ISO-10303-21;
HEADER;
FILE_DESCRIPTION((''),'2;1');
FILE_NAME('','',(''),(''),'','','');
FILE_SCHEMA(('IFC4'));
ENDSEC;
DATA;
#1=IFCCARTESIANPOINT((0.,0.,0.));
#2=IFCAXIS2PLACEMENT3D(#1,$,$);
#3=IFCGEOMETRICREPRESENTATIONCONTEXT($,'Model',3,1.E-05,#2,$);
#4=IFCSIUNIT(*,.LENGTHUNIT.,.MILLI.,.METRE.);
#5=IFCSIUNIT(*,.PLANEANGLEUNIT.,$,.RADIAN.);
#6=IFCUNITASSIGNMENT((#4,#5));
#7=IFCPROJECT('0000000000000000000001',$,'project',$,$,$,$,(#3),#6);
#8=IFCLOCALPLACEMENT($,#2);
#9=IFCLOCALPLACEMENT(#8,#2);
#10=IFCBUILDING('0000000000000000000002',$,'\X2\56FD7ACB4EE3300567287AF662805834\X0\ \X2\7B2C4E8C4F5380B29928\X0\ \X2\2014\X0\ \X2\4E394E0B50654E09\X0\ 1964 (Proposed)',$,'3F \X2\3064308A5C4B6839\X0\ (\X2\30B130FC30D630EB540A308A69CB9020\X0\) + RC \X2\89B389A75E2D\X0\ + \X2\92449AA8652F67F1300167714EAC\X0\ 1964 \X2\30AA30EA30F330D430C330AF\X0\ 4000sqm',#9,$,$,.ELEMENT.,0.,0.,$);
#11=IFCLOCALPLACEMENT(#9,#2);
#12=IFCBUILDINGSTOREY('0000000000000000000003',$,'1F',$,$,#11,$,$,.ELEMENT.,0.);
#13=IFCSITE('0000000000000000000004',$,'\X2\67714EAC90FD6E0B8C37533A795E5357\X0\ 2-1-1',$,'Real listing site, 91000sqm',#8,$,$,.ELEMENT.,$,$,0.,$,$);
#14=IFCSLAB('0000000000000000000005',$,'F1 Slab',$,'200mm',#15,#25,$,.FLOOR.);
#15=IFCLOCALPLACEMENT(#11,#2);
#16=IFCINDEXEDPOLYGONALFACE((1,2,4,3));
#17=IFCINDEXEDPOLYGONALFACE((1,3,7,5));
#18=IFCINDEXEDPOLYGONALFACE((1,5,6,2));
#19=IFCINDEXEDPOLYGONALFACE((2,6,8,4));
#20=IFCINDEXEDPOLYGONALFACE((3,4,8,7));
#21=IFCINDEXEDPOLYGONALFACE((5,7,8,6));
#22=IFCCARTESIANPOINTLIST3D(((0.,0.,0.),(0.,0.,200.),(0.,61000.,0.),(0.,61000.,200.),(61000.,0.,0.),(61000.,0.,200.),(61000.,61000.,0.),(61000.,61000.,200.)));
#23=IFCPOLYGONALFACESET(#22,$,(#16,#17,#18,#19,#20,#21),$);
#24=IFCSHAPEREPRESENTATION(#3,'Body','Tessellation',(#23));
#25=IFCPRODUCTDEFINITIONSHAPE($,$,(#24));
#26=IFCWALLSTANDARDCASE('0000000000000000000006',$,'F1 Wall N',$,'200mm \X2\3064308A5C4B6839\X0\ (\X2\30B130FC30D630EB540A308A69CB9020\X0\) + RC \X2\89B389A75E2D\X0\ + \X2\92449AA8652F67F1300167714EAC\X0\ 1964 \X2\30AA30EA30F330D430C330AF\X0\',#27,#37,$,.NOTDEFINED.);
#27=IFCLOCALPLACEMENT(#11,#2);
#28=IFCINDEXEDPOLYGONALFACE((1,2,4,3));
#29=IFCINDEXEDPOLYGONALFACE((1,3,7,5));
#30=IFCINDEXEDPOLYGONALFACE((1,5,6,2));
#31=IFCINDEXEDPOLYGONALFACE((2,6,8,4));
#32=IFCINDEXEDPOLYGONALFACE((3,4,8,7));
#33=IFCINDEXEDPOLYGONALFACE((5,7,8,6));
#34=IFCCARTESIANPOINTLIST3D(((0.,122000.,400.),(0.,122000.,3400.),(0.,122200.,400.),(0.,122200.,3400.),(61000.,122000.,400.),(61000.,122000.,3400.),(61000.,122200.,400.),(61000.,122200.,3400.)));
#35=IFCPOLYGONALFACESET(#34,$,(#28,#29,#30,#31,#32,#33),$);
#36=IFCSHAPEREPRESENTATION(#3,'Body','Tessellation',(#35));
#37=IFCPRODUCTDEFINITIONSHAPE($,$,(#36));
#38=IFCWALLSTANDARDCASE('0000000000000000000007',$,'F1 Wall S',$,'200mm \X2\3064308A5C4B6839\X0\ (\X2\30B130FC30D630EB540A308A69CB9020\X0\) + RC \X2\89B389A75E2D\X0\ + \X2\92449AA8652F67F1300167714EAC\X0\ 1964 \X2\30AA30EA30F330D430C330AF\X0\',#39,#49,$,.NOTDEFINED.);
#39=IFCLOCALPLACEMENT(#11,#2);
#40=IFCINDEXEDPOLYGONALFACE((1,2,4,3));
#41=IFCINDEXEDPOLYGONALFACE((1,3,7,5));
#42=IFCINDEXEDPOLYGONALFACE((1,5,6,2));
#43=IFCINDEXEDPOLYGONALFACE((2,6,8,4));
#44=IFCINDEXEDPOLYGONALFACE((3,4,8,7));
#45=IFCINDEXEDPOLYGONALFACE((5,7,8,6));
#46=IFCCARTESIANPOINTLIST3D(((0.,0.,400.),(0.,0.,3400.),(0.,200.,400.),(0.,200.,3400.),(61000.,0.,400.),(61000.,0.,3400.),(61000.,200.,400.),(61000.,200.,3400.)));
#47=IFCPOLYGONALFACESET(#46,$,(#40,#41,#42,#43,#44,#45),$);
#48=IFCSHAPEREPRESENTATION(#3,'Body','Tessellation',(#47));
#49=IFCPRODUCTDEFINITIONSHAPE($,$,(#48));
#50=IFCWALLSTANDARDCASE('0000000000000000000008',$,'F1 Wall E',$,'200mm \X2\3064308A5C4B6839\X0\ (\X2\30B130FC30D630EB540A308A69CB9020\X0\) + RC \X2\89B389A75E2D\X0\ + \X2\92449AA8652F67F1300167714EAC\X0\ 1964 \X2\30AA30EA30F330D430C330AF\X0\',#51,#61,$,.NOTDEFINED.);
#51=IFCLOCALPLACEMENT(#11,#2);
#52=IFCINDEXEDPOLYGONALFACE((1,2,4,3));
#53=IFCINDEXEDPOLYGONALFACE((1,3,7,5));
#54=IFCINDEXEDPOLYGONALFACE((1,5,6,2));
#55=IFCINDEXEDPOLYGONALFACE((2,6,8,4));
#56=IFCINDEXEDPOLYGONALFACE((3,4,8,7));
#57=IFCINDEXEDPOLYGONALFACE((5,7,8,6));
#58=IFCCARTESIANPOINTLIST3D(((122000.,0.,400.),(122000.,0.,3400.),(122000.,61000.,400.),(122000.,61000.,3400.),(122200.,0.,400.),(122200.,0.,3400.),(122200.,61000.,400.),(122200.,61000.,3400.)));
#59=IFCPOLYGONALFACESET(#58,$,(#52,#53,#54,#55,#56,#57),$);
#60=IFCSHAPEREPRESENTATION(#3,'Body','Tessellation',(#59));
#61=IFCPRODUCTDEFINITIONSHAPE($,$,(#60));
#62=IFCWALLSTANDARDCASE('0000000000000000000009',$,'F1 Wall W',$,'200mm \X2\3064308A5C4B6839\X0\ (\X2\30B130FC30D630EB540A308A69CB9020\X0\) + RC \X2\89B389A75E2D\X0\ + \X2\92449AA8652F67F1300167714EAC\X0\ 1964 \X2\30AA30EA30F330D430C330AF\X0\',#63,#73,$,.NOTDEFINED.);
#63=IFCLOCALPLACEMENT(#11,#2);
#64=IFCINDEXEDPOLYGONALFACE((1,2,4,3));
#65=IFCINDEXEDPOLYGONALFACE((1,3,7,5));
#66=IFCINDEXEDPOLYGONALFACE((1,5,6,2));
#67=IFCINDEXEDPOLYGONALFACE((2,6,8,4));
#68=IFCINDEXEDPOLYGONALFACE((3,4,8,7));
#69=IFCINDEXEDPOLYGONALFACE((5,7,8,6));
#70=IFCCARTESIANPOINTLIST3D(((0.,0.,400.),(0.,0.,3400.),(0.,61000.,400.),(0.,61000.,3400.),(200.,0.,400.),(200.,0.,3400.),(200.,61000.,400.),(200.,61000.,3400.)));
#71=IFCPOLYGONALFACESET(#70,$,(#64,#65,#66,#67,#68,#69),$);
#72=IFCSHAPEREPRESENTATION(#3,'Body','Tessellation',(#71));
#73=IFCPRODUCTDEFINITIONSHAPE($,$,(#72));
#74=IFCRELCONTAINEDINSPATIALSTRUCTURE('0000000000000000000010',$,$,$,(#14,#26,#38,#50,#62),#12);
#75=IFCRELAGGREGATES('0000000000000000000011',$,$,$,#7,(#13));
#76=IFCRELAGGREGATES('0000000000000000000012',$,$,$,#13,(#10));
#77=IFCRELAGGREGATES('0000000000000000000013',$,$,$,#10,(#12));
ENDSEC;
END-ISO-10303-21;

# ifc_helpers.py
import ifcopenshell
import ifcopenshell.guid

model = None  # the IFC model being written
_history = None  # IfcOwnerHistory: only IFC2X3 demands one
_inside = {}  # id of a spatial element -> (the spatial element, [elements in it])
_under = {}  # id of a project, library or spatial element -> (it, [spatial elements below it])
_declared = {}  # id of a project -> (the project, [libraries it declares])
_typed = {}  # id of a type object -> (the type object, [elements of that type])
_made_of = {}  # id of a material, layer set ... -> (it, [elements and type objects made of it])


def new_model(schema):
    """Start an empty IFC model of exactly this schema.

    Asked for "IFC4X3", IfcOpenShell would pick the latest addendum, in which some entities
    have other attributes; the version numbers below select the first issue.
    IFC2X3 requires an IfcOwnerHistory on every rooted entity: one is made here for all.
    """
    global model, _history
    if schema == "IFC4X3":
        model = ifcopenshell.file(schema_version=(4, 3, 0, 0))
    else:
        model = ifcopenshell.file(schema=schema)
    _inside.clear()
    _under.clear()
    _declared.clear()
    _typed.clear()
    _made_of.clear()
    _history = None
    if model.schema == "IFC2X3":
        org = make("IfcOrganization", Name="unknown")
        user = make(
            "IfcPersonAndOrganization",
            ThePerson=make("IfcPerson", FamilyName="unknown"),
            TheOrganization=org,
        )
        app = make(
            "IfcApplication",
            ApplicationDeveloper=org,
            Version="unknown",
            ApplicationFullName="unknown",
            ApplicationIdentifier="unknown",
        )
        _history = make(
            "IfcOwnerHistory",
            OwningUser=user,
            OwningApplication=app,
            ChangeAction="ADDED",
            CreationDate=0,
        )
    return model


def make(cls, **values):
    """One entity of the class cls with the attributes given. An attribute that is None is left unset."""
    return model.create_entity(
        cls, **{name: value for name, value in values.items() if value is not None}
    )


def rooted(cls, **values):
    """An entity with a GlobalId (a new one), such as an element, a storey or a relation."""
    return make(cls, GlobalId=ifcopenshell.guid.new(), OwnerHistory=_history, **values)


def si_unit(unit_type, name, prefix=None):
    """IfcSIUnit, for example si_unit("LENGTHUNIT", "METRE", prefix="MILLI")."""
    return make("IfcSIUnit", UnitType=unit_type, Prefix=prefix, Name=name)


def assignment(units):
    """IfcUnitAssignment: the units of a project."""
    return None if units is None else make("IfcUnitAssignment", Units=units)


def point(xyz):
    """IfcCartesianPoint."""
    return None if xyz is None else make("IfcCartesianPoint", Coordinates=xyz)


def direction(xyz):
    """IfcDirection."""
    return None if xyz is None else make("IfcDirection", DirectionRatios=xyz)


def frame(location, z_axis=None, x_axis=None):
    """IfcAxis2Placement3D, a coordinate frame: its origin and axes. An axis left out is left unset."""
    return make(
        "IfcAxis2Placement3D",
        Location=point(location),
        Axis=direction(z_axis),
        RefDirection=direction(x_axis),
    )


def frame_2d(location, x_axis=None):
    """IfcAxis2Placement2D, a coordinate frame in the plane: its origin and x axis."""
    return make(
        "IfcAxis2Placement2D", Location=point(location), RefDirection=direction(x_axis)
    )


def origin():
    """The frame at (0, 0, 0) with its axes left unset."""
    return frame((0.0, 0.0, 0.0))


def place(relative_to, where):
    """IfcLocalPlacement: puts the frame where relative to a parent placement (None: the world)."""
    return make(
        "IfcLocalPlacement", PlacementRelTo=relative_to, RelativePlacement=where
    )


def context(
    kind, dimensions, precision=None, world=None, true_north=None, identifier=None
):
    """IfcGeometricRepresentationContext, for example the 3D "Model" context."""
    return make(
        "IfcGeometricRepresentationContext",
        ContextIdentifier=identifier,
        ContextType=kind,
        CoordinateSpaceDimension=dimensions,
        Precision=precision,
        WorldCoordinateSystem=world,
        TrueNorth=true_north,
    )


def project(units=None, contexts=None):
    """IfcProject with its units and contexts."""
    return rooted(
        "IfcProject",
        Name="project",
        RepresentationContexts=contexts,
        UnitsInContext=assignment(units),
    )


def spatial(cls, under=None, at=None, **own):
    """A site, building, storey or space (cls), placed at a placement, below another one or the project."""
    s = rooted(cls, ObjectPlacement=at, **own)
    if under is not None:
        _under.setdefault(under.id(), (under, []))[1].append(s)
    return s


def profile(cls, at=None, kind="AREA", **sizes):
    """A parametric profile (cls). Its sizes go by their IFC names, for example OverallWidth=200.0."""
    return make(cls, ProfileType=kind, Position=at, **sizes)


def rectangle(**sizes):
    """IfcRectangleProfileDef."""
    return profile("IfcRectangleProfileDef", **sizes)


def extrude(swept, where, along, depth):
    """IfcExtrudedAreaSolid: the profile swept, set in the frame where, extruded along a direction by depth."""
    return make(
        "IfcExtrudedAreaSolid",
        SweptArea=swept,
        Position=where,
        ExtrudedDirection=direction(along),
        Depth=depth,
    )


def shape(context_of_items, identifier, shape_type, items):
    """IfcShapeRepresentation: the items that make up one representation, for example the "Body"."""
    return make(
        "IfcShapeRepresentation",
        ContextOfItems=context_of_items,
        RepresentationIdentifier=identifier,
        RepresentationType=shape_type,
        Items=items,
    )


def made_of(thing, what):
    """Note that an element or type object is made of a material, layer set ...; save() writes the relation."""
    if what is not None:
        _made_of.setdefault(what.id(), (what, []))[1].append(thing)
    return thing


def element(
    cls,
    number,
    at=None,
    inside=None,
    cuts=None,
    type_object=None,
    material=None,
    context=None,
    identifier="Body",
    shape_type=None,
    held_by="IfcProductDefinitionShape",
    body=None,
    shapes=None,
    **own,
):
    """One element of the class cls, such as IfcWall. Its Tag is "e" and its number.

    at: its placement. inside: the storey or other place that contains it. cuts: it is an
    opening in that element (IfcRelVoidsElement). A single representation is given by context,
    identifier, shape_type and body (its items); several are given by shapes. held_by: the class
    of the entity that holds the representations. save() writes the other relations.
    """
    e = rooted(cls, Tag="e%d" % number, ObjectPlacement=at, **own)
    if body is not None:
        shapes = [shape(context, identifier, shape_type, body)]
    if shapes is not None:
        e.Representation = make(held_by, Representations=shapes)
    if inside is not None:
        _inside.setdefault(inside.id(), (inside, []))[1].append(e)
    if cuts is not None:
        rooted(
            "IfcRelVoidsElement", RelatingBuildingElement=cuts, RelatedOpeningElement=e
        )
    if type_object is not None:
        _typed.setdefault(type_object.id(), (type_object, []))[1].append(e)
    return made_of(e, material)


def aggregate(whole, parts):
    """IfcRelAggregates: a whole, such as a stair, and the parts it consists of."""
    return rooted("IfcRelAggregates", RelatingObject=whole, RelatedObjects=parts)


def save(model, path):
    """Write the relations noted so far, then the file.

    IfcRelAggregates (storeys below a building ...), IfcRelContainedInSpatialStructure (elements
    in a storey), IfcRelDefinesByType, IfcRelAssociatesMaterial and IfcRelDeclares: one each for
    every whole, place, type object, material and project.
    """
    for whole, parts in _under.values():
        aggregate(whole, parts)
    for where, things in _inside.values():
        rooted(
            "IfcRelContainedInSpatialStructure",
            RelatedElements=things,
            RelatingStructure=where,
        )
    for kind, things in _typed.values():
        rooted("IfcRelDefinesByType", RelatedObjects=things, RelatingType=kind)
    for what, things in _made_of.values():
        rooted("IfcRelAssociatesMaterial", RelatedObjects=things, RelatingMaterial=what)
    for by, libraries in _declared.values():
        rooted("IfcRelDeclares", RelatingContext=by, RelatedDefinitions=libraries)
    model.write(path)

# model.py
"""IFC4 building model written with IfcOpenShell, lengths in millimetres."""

from ifc_helpers import new_model, si_unit, frame, frame_2d, origin, place, context, project, spatial, rectangle, extrude, element, save


model = new_model("IFC4")

# Units and contexts
model_context = context("Model", 3, precision=1e-05, world=origin())
ifc_project = project(units=[si_unit("LENGTHUNIT", "METRE", prefix="MILLI"), si_unit("PLANEANGLEUNIT", "RADIAN")], contexts=[model_context])

# Site, building, storey
site_placement = place(None, origin())
site = spatial("IfcSite", under=ifc_project, at=site_placement, Name="東京都渋谷区神南 2-1-1", ObjectType="Real listing site, 91000sqm", CompositionType="ELEMENT", RefElevation=0.0)
building_placement = place(site_placement, origin())
building = spatial("IfcBuilding", under=site, at=building_placement, Name="国立代々木競技場 第二体育館 — 丹下健三 1964 (Proposed)", ObjectType="3F つり屋根 (ケーブル吊り構造) + RC 観覧席 + 鉄骨支柱、東京 1964 オリンピック 4000sqm", CompositionType="ELEMENT", ElevationOfRefHeight=0.0, ElevationOfTerrain=0.0)
storey_placement = place(building_placement, origin())
storey = spatial("IfcBuildingStorey", under=building, at=storey_placement, Name="1F", CompositionType="ELEMENT", Elevation=0.0)

# Slab
slab_placement = place(storey_placement, origin())
element("IfcSlab", 1, at=slab_placement, inside=storey, Name="F1 Slab", ObjectType="200mm", PredefinedType="FLOOR", context=model_context, shape_type="SweptSolid", body=[
    extrude(rectangle(XDim=61000.0, YDim=61000.0, at=frame_2d((30500.0, 30500.0))), origin(), (0.0, 0.0, 1.0), 200.0),
])

# Walls
wall_1_placement = place(storey_placement, frame((0.0, 61000.0, 200.0)))
element("IfcWallStandardCase", 2, at=wall_1_placement, inside=storey, Name="F1 Wall N", ObjectType="200mm つり屋根 (ケーブル吊り構造) + RC 観覧席 + 鉄骨支柱、東京 1964 オリンピック", PredefinedType="NOTDEFINED", context=model_context, shape_type="SweptSolid", body=[
    extrude(rectangle(XDim=61000.0, YDim=200.0, at=frame_2d((30500.0, 100.0))), frame((0.0, 61000.0, 200.0)), (0.0, 0.0, 1.0), 3000.0),
])
wall_2_placement = place(storey_placement, frame((0.0, 0.0, 200.0)))
element("IfcWallStandardCase", 3, at=wall_2_placement, inside=storey, Name="F1 Wall S", ObjectType="200mm つり屋根 (ケーブル吊り構造) + RC 観覧席 + 鉄骨支柱、東京 1964 オリンピック", PredefinedType="NOTDEFINED", context=model_context, shape_type="SweptSolid", body=[
    extrude(rectangle(XDim=61000.0, YDim=200.0, at=frame_2d((30500.0, 100.0))), frame((0.0, 0.0, 200.0)), (0.0, 0.0, 1.0), 3000.0),
])
wall_3_placement = place(storey_placement, frame((61000.0, 0.0, 200.0)))
element("IfcWallStandardCase", 4, at=wall_3_placement, inside=storey, Name="F1 Wall E", ObjectType="200mm つり屋根 (ケーブル吊り構造) + RC 観覧席 + 鉄骨支柱、東京 1964 オリンピック", PredefinedType="NOTDEFINED", context=model_context, shape_type="SweptSolid", body=[
    extrude(rectangle(XDim=200.0, YDim=61000.0, at=frame_2d((100.0, 30500.0))), frame((61000.0, 0.0, 200.0)), (0.0, 0.0, 1.0), 3000.0),
])
wall_4_placement = place(storey_placement, frame((0.0, 0.0, 200.0)))
element("IfcWallStandardCase", 5, at=wall_4_placement, inside=storey, Name="F1 Wall W", ObjectType="200mm つり屋根 (ケーブル吊り構造) + RC 観覧席 + 鉄骨支柱、東京 1964 オリンピック", PredefinedType="NOTDEFINED", context=model_context, shape_type="SweptSolid", body=[
    extrude(rectangle(XDim=200.0, YDim=61000.0, at=frame_2d((100.0, 30500.0))), frame((0.0, 0.0, 200.0)), (0.0, 0.0, 1.0), 3000.0),
])

save(model, "model.ifc")
